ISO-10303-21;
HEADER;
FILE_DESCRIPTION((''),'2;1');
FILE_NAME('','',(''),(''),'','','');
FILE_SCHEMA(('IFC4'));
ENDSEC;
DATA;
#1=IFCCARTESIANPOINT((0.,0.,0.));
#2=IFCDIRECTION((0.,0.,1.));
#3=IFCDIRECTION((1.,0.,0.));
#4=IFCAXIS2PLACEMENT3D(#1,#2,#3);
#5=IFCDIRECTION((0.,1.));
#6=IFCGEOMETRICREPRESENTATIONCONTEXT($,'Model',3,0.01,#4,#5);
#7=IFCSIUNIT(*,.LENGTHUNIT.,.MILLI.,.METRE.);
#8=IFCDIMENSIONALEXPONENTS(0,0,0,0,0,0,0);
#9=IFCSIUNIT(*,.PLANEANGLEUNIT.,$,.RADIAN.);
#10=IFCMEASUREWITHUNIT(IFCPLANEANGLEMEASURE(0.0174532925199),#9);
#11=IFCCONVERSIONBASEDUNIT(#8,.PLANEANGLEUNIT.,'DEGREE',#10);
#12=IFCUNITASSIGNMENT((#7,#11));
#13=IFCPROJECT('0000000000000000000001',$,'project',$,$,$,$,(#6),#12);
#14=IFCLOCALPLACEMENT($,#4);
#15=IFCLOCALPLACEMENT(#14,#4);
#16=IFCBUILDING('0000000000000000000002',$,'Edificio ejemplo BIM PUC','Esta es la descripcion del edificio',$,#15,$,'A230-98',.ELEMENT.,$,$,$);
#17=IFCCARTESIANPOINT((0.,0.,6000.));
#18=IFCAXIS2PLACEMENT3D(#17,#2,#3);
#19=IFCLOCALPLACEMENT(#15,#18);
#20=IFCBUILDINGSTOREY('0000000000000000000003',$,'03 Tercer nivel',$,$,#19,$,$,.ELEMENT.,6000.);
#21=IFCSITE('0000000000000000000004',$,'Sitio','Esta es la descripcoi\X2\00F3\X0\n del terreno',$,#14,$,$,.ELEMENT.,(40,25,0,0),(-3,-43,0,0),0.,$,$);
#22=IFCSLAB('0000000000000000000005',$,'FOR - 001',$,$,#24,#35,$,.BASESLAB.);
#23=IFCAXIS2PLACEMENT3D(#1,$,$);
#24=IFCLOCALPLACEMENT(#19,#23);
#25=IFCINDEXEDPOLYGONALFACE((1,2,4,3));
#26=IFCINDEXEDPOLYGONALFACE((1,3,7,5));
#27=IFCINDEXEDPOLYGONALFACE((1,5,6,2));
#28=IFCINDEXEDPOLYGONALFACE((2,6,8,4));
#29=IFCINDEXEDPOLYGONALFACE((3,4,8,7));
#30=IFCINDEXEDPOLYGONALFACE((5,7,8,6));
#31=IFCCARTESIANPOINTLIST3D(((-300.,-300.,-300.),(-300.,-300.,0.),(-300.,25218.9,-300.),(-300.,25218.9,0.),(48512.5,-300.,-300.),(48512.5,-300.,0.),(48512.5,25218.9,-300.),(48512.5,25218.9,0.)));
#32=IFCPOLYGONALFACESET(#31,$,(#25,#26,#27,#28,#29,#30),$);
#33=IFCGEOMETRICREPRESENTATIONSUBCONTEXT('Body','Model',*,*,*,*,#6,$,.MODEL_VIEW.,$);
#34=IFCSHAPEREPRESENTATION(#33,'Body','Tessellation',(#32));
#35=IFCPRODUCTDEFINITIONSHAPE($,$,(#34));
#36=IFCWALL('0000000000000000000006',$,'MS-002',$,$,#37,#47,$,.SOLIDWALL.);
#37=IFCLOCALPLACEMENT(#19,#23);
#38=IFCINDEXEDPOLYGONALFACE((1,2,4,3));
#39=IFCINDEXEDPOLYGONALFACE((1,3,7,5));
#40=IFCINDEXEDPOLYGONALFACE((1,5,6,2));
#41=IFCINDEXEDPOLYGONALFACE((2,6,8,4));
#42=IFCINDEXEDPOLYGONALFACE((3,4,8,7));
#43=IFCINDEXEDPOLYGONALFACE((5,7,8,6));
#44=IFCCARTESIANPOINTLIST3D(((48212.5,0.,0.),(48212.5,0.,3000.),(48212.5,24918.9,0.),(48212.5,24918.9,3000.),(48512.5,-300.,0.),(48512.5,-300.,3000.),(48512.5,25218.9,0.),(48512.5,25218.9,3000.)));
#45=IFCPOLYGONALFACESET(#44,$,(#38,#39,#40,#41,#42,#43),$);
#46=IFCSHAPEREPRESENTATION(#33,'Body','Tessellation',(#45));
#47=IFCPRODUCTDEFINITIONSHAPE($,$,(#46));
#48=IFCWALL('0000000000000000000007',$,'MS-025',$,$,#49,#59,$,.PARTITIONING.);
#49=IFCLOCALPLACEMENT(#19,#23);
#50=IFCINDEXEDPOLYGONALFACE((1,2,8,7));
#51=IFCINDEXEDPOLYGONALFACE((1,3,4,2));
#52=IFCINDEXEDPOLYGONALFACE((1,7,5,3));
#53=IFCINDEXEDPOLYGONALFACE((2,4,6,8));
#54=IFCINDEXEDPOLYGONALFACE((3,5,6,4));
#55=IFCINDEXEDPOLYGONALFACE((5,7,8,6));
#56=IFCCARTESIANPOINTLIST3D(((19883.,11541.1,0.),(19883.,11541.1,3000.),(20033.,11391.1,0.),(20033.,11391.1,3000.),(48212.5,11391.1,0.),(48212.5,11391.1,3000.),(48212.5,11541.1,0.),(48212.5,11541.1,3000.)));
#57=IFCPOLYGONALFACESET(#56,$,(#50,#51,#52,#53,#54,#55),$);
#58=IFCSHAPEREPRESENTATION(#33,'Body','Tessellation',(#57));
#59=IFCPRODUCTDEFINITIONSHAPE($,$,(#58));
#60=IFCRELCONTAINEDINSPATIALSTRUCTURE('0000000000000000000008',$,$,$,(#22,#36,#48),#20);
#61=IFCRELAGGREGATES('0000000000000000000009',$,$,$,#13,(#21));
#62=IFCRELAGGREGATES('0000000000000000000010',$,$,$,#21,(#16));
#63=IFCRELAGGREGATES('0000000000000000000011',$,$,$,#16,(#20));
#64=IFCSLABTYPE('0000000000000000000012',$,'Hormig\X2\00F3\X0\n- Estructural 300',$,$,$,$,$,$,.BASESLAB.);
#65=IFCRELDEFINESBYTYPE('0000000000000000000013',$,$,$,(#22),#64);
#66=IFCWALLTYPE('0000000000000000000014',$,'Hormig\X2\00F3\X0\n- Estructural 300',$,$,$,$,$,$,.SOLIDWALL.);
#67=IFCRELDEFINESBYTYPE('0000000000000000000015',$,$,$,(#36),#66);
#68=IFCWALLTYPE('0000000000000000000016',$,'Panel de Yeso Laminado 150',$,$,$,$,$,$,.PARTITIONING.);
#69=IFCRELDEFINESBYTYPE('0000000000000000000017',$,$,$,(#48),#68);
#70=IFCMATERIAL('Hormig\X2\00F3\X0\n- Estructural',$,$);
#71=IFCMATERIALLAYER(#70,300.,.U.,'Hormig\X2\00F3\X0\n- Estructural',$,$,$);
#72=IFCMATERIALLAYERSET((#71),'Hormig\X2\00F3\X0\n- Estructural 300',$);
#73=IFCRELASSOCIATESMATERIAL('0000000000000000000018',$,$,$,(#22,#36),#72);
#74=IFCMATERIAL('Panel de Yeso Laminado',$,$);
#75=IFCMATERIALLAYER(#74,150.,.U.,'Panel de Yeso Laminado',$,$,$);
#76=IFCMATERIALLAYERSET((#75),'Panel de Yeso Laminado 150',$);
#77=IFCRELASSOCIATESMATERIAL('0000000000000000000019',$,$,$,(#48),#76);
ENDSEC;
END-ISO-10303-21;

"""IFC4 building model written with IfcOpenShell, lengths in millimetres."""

from ifc_helpers import new_model, entity, si_unit, converted_unit, direction, frame, origin_with_axes, place, context, subcontext, project, spatial, line, indexed_curve, outline, extrude, material, layer, layer_set, layer_usage, type_object, element, save


model = new_model("IFC4")

# Units and contexts
model_context = context("Model", 3, precision=0.01, world=origin_with_axes(), true_north=direction((0.0, 1.0)))
body_context = subcontext(model_context, "Body", "Model", "MODEL_VIEW")
ifc_project = project(units=[si_unit("LENGTHUNIT", "METRE", prefix="MILLI"), converted_unit("PLANEANGLEUNIT", "DEGREE", entity("IfcPlaneAngleMeasure", 0.0174532925199), si_unit("PLANEANGLEUNIT", "RADIAN"), dimensions=[0, 0, 0, 0, 0, 0, 0])], contexts=[model_context])

# Site, building, storey
site_placement = place(None, origin_with_axes())
site = spatial("IfcSite", under=ifc_project, at=site_placement, Name="Sitio", Description="Esta es la descripcoión del terreno", CompositionType="ELEMENT", RefLatitude=(40, 25, 0, 0), RefLongitude=(-3, -43, 0, 0), RefElevation=0.0)
building_placement = place(site_placement, origin_with_axes())
building = spatial("IfcBuilding", under=site, at=building_placement, Name="Edificio ejemplo BIM PUC", Description="Esta es la descripcion del edificio", LongName="A230-98", CompositionType="ELEMENT")
storey_placement = place(building_placement, frame((0.0, 0.0, 6000.0), z_axis=(0.0, 0.0, 1.0), x_axis=(1.0, 0.0, 0.0)))
storey = spatial("IfcBuildingStorey", under=building, at=storey_placement, Name="03 Tercer nivel", CompositionType="ELEMENT", Elevation=6000.0)

# Slab
ifc_material_1 = material(Name="Hormigón- Estructural")
ifc_layer_1 = layer(ifc_material_1, 300.0, ventilated="UNKNOWN", Name="Hormigón- Estructural")
ifc_layer_set_1 = layer_set([ifc_layer_1], Name="Hormigón- Estructural 300")
ifc_layer_usage_1 = layer_usage(ifc_layer_set_1, "AXIS3", "NEGATIVE", 300.0)
slab_type = type_object("IfcSlabType", Name="Hormigón- Estructural 300", PredefinedType="BASESLAB")
slab_placement = place(storey_placement, frame((-300.0, -300.0, 0.0), z_axis=(0.0, 0.0, 1.0), x_axis=(1.0, 0.0, 0.0)))
element("IfcSlab", 1, at=slab_placement, inside=storey, type_object=slab_type, material=ifc_layer_usage_1, Name="FOR - 001", PredefinedType="BASESLAB", context=body_context, shape_type="SweptSolid", body=[
    extrude(outline(indexed_curve([(0.0, 0.0), (48812.5, 0.0), (48812.5, 25518.9), (0.0, 25518.9)], segments=[line(1, 2, 3, 4, 1)])), frame((0.0, 0.0, -300.0), z_axis=(0.0, 0.0, 1.0), x_axis=(1.0, 0.0, 0.0)), (0.0, 0.0, 1.0), 300.0),
])

# Walls
ifc_layer_usage_2 = layer_usage(ifc_layer_set_1, "AXIS2", "POSITIVE", 0.0)
wall_type_1 = type_object("IfcWallType", Name="Hormigón- Estructural 300", PredefinedType="SOLIDWALL")
wall_1_placement = place(storey_placement, frame((48212.5, 24918.9, 0.0), z_axis=(0.0, 0.0, 1.0), x_axis=(0.0, -1.0, 0.0)))
element("IfcWall", 2, at=wall_1_placement, inside=storey, type_object=wall_type_1, material=ifc_layer_usage_2, Name="MS-002", PredefinedType="SOLIDWALL", context=body_context, shape_type="SweptSolid", body=[
    extrude(outline(indexed_curve([(0.0, 0.0), (24918.9, 0.0), (25218.9, 300.0), (-300.0, 300.0)], segments=[line(1, 2, 3, 4, 1)])), origin_with_axes(), (0.0, 0.0, 1.0), 3000.0),
])
ifc_material_2 = material(Name="Panel de Yeso Laminado")
ifc_layer_2 = layer(ifc_material_2, 150.0, ventilated="UNKNOWN", Name="Panel de Yeso Laminado")
ifc_layer_set_2 = layer_set([ifc_layer_2], Name="Panel de Yeso Laminado 150")
wall_type_2 = type_object("IfcWallType", Name="Panel de Yeso Laminado 150", PredefinedType="PARTITIONING")
ifc_layer_usage_3 = layer_usage(ifc_layer_set_2, "AXIS2", "POSITIVE", 0.0)
wall_2_placement = place(storey_placement, frame((20033.0, 11391.1, 0.0), z_axis=(0.0, 0.0, 1.0), x_axis=(1.0, 0.0, 0.0)))
element("IfcWall", 3, at=wall_2_placement, inside=storey, type_object=wall_type_2, material=ifc_layer_usage_3, Name="MS-025", PredefinedType="PARTITIONING", context=body_context, shape_type="SweptSolid", body=[
    extrude(outline(indexed_curve([(0.0, 0.0), (28179.5, 0.0), (28179.5, 150.0), (-150.0, 150.0)], segments=[line(1, 2, 3, 4, 1)])), origin_with_axes(), (0.0, 0.0, 1.0), 3000.0),
])

save(model, "model.ifc")
